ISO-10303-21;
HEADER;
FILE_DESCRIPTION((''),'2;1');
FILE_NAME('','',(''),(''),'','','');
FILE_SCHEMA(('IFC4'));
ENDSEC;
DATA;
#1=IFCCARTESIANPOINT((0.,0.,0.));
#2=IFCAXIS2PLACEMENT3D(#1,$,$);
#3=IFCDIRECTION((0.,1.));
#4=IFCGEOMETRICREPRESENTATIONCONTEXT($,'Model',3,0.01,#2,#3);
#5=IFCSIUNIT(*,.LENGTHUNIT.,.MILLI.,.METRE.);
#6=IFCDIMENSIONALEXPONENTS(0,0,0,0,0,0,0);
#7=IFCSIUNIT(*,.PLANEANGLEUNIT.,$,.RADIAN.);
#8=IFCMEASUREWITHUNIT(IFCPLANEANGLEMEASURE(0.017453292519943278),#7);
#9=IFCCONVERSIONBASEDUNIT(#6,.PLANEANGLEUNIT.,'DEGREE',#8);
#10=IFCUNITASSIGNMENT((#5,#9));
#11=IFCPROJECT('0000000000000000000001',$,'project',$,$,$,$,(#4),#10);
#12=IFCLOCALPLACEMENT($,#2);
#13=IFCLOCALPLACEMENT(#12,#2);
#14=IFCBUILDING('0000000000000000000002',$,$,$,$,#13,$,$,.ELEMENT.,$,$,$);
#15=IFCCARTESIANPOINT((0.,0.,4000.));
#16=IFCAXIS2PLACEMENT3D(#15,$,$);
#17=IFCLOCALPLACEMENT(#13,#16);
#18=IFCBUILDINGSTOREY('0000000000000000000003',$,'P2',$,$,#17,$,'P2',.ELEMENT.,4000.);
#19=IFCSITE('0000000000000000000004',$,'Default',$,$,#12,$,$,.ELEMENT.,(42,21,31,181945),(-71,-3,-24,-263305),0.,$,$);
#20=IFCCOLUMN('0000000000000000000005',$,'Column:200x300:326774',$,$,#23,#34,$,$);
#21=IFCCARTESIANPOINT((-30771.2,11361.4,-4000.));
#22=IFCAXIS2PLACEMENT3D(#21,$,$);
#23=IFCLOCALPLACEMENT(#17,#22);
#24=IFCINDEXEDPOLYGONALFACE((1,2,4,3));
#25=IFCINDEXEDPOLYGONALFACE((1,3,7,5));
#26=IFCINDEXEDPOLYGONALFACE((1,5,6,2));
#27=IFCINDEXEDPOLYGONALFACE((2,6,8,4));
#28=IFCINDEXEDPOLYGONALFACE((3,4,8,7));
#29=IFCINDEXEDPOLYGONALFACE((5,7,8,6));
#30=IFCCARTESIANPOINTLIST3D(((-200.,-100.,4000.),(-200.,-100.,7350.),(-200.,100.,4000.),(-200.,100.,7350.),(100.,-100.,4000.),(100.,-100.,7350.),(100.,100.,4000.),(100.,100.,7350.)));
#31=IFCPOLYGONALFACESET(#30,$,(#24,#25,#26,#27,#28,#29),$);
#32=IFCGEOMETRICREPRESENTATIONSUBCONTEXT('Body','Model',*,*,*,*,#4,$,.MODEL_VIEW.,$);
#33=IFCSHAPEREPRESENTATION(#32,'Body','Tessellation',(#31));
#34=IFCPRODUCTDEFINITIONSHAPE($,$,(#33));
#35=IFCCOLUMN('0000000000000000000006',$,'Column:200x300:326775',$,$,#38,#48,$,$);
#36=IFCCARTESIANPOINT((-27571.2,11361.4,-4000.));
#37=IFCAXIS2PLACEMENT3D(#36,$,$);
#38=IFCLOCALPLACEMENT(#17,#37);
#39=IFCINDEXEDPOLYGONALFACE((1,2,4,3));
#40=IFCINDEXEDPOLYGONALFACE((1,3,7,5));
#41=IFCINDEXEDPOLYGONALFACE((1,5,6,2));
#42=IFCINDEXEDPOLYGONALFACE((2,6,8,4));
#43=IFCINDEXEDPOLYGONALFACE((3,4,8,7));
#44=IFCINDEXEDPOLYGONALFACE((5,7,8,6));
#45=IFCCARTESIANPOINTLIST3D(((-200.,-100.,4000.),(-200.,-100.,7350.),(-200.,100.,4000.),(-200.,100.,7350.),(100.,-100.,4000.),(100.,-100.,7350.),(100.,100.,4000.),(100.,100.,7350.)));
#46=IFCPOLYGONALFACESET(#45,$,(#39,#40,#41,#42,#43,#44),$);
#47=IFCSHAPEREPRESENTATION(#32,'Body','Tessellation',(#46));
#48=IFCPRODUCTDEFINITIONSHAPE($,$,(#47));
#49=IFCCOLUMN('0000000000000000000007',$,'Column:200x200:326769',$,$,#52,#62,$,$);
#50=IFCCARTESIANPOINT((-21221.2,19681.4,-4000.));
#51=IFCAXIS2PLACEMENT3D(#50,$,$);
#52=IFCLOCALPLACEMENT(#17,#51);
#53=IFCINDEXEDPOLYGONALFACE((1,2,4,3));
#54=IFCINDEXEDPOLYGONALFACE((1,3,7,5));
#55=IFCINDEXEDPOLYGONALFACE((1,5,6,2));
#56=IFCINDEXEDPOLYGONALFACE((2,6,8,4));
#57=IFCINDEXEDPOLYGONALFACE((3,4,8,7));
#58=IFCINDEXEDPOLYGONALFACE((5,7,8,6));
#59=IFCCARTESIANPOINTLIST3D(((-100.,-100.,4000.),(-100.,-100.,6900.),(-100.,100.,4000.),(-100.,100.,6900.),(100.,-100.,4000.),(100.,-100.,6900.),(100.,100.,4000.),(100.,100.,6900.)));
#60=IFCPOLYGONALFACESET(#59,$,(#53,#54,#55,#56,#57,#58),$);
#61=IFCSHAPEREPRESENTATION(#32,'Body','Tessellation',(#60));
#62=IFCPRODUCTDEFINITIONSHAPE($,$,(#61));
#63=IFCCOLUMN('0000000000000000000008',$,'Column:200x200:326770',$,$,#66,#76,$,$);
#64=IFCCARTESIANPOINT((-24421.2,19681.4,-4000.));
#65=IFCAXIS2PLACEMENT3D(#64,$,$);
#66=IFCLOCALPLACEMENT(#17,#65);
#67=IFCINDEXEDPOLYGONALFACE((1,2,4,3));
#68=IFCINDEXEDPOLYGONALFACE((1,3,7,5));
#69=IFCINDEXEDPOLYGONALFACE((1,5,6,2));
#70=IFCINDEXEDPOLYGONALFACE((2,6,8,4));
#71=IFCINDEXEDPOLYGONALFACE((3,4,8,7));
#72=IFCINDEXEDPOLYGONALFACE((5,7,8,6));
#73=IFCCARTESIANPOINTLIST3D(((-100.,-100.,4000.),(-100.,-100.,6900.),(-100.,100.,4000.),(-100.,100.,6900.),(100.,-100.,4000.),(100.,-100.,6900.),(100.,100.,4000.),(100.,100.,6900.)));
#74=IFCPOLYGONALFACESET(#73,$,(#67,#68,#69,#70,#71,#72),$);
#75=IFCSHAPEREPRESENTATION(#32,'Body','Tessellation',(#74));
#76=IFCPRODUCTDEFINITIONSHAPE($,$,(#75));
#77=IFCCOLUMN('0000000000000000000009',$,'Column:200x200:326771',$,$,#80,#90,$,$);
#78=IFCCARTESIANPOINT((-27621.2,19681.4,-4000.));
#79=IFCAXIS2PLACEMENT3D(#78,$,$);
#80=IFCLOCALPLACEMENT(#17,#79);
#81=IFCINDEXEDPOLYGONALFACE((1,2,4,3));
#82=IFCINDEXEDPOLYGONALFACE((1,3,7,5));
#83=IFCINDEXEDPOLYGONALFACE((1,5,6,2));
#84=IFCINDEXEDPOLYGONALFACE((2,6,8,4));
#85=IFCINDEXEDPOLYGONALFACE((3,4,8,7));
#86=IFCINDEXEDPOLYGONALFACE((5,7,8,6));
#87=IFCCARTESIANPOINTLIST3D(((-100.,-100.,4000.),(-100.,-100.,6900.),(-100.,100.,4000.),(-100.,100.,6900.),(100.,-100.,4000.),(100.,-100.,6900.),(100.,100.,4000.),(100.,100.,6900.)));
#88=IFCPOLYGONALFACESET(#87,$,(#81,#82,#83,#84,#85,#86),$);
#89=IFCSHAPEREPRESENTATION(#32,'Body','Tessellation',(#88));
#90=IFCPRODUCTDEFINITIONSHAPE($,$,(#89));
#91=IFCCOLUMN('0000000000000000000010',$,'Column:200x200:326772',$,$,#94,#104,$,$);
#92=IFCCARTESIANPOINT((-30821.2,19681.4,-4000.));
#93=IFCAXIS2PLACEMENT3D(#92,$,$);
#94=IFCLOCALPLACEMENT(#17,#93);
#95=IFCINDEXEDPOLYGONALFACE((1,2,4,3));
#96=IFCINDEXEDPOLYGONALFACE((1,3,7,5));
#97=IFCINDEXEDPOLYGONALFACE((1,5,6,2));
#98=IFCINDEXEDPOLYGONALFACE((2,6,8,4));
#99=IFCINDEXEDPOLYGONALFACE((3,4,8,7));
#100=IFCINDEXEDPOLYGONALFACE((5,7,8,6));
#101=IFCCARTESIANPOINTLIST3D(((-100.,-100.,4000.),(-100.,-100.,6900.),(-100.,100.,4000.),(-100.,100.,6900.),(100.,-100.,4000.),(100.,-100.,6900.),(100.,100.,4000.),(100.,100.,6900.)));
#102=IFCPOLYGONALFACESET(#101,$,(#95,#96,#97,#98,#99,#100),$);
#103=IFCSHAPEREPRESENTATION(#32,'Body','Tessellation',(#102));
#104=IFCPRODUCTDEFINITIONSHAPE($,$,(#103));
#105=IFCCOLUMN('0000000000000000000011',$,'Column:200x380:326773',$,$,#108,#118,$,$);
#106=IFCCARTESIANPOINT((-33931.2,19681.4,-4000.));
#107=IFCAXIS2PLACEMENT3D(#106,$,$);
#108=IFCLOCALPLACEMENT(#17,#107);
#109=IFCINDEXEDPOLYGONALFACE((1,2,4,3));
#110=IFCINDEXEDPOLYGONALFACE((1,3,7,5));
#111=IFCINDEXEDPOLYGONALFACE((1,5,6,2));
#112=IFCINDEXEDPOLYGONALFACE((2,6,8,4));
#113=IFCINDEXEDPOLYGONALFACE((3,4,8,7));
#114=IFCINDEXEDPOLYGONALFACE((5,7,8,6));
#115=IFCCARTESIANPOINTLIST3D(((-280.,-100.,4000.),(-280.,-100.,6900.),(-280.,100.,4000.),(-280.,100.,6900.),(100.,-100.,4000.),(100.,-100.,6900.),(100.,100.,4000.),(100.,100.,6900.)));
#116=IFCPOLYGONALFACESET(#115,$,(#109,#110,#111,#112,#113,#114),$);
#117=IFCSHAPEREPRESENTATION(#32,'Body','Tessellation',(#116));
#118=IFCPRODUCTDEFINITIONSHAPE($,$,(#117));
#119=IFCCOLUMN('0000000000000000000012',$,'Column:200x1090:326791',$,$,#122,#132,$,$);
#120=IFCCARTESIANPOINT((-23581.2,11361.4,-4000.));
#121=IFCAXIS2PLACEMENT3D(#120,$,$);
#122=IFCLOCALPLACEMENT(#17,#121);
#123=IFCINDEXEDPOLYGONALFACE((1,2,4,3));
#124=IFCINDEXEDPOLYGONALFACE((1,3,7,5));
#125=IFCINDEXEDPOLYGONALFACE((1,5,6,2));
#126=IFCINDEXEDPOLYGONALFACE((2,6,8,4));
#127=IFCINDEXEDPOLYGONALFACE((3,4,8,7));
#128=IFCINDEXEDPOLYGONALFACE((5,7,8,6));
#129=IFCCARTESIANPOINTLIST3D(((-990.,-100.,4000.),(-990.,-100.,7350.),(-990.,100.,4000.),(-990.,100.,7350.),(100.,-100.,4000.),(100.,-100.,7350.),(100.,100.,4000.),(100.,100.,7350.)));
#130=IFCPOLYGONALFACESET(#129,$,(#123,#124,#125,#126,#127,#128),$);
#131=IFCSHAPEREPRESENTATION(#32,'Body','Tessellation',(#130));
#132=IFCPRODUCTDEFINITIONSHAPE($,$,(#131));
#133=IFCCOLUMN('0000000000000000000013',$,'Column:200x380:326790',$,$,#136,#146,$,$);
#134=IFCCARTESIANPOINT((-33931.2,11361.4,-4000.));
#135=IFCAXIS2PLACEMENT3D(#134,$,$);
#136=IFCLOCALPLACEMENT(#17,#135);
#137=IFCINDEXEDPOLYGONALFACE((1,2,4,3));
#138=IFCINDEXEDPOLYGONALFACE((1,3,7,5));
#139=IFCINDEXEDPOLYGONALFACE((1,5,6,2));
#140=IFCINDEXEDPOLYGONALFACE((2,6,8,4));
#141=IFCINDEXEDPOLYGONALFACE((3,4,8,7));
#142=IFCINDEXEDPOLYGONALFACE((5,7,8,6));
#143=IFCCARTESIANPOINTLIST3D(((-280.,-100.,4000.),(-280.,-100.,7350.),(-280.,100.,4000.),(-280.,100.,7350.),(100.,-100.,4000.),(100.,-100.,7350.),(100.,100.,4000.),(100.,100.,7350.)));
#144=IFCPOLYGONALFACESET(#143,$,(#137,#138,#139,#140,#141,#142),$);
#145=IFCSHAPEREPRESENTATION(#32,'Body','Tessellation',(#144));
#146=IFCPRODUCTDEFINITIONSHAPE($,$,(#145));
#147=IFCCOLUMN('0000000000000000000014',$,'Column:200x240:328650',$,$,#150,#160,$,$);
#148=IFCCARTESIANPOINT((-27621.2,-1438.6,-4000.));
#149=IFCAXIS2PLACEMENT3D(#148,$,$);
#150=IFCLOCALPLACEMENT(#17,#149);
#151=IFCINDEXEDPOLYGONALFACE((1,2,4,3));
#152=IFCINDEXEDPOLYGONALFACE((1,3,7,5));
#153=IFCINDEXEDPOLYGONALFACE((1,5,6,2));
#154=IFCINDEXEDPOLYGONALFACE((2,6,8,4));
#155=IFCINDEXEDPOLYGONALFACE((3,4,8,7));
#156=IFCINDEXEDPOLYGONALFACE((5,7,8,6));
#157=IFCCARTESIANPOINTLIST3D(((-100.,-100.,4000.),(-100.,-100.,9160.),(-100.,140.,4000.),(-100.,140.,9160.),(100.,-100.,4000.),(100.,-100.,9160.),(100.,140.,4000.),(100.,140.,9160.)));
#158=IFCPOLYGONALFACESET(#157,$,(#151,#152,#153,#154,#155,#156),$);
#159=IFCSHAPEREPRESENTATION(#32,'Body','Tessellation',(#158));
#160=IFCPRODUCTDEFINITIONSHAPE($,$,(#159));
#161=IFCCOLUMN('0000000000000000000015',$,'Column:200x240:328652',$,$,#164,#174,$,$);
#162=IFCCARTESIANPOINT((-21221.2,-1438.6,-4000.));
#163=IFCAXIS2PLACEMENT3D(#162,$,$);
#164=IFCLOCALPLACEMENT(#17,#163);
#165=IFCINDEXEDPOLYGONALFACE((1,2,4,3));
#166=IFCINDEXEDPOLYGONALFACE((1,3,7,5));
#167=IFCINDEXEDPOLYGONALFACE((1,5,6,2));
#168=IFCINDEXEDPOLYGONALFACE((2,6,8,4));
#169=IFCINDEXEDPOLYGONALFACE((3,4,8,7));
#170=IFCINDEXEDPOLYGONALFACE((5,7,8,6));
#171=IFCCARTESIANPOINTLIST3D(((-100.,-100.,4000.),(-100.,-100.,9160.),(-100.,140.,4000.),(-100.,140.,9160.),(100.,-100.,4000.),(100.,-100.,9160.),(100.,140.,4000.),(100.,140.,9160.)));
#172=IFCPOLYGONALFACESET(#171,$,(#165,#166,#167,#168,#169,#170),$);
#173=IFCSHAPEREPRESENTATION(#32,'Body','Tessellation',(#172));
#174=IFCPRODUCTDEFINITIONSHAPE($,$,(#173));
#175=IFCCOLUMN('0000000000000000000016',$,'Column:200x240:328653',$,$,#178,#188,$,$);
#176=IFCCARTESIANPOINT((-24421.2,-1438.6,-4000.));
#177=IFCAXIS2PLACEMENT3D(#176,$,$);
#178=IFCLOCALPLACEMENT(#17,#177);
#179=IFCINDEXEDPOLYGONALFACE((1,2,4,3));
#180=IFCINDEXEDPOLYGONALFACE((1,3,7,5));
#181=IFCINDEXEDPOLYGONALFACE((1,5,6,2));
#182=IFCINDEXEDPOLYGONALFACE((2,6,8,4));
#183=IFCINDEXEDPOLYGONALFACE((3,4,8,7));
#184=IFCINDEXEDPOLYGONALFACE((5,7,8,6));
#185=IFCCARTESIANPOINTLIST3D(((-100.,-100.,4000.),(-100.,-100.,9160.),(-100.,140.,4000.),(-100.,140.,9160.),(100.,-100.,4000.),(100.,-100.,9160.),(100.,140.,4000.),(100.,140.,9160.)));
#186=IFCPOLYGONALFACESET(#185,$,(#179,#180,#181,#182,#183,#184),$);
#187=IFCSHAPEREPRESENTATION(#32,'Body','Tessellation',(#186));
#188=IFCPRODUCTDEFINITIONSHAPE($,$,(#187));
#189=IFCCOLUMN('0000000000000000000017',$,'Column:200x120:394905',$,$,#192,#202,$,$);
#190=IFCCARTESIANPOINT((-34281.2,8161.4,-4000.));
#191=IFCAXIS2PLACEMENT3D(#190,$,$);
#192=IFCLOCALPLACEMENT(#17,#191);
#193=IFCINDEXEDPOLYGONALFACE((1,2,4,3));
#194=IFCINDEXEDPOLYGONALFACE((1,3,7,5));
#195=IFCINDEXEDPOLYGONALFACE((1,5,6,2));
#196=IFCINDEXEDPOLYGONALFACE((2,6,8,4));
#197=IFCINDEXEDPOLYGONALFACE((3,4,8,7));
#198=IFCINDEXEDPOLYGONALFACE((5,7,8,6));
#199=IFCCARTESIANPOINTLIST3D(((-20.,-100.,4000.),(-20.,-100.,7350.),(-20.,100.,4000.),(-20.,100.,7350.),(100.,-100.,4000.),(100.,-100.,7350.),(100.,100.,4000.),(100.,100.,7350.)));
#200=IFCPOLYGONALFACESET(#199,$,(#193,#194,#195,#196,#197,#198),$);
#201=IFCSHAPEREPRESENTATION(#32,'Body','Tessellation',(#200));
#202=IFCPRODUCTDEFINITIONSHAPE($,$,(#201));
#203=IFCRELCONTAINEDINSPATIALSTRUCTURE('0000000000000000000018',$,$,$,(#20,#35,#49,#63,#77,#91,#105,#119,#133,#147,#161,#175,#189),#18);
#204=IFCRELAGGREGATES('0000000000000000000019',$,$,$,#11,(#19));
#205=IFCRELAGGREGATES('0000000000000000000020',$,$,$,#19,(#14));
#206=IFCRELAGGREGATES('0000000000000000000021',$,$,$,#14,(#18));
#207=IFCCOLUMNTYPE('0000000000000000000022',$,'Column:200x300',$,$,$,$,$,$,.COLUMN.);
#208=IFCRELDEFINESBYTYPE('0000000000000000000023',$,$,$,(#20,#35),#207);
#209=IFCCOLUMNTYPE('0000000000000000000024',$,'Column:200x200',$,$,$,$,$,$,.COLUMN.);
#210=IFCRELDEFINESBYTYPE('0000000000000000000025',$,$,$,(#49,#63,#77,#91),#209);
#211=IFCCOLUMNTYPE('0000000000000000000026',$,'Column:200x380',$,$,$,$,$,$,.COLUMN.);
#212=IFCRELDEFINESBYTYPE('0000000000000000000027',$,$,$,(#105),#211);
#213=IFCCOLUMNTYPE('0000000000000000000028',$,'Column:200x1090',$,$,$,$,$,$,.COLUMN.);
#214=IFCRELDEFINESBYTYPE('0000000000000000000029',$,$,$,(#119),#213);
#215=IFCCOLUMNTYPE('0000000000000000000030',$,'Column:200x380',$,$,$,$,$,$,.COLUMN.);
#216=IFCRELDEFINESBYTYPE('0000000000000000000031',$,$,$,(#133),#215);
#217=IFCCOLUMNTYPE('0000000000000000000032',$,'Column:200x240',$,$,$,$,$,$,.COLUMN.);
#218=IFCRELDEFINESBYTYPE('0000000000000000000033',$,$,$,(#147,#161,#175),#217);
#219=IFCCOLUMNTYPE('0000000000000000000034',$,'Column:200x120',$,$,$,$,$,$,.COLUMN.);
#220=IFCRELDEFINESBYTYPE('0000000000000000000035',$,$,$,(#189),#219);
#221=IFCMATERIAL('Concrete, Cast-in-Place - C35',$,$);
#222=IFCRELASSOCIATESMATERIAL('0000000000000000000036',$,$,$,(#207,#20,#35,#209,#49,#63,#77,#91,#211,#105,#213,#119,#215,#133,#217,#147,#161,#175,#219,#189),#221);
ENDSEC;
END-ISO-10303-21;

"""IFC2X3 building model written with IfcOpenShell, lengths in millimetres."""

from ifc_helpers import new_model, entity, si_unit, converted_unit, direction, frame, frame_2d, origin, origin_2d_with_axis, place, context, subcontext, project, spatial, rectangle, extrude, source, transform, mapped, material, type_object, type_shapes, element, save


model = new_model("IFC2X3")

# Units and contexts
model_context = context("Model", 3, precision=0.01, world=origin(), true_north=direction((0.0, 1.0)))
body_context = subcontext(model_context, "Body", "Model", "MODEL_VIEW")
ifc_project = project(units=[si_unit("LENGTHUNIT", "METRE", prefix="MILLI"), converted_unit("PLANEANGLEUNIT", "DEGREE", entity("IfcPlaneAngleMeasure", 0.017453292519943278), si_unit("PLANEANGLEUNIT", "RADIAN"), dimensions=[0, 0, 0, 0, 0, 0, 0])], contexts=[model_context])

# Site, building, storey
site_placement = place(None, origin())
site = spatial("IfcSite", under=ifc_project, at=site_placement, Name="Default", CompositionType="ELEMENT", RefLatitude=(42, 21, 31, 181945), RefLongitude=(-71, -3, -24, -263305), RefElevation=0.0)
building_placement = place(site_placement, origin())
building = spatial("IfcBuilding", under=site, at=building_placement, CompositionType="ELEMENT")
storey_placement = place(building_placement, frame((0.0, 0.0, 4000.0)))
storey = spatial("IfcBuildingStorey", under=building, at=storey_placement, Name="P2", LongName="P2", CompositionType="ELEMENT", Elevation=4000.0)

# Columns
ifc_material = material(Name="Concrete, Cast-in-Place - C35")
column_type_1 = type_object("IfcColumnType", Name="Column:200x300", PredefinedType="COLUMN", material=ifc_material)
shared_shape_1 = source(origin(), body_context, "Body", "SweptSolid", [
    extrude(rectangle(XDim=300.0, YDim=200.0, at=origin_2d_with_axis()), frame((-50.0, 0.0, 4000.0), z_axis=(0.0, 0.0, 1.0), x_axis=(-1.0, 0.0, 0.0)), (0.0, 0.0, 1.0), 3350.0),
])
type_shapes(column_type_1, [shared_shape_1])
for number, where, name in (
    (1, (-30771.2, 11361.4, -4000.0), "Column:200x300:326774"),
    (2, (-27571.2, 11361.4, -4000.0), "Column:200x300:326775"),
):
    element("IfcColumn", number, at=place(storey_placement, frame(where)), inside=storey, type_object=column_type_1, material=ifc_material, Name=name, context=body_context, shape_type="MappedRepresentation", body=[
        mapped(shared_shape_1, transform((0.0, 0.0, 0.0), scale=1.0)),
    ])
column_type_2 = type_object("IfcColumnType", Name="Column:200x200", PredefinedType="COLUMN", material=ifc_material)
shared_shape_2 = source(origin(), body_context, "Body", "SweptSolid", [
    extrude(rectangle(XDim=200.0, YDim=200.0, at=frame_2d((0.0, 0.0), x_axis=(1.0, 0.0))), frame((0.0, 0.0, 4000.0), z_axis=(0.0, 0.0, 1.0), x_axis=(-1.0, 0.0, 0.0)), (0.0, 0.0, 1.0), 2900.0),
])
type_shapes(column_type_2, [shared_shape_2])
for number, where, name in (
    (3, (-21221.2, 19681.4, -4000.0), "Column:200x200:326769"),
    (4, (-24421.2, 19681.4, -4000.0), "Column:200x200:326770"),
    (5, (-27621.2, 19681.4, -4000.0), "Column:200x200:326771"),
    (6, (-30821.2, 19681.4, -4000.0), "Column:200x200:326772"),
):
    element("IfcColumn", number, at=place(storey_placement, frame(where)), inside=storey, type_object=column_type_2, material=ifc_material, Name=name, context=body_context, shape_type="MappedRepresentation", body=[
        mapped(shared_shape_2, transform((0.0, 0.0, 0.0), scale=1.0)),
    ])
column_type_3 = type_object("IfcColumnType", Name="Column:200x380", PredefinedType="COLUMN", material=ifc_material)
shared_shape_3 = source(origin(), body_context, "Body", "SweptSolid", [
    extrude(rectangle(XDim=380.0, YDim=200.0, at=origin_2d_with_axis()), frame((-90.0, 0.0, 4000.0), z_axis=(0.0, 0.0, 1.0), x_axis=(-1.0, 0.0, 0.0)), (0.0, 0.0, 1.0), 2900.0),
])
type_shapes(column_type_3, [shared_shape_3])
column_1_placement = place(storey_placement, frame((-33931.2, 19681.4, -4000.0)))
element("IfcColumn", 7, at=column_1_placement, inside=storey, type_object=column_type_3, material=ifc_material, Name="Column:200x380:326773", context=body_context, shape_type="MappedRepresentation", body=[
    mapped(shared_shape_3, transform((0.0, 0.0, 0.0), scale=1.0)),
])
column_type_4 = type_object("IfcColumnType", Name="Column:200x1090", PredefinedType="COLUMN", material=ifc_material)
shared_shape_4 = source(origin(), body_context, "Body", "SweptSolid", [
    extrude(rectangle(XDim=1090.0, YDim=200.0, at=origin_2d_with_axis()), frame((-445.0, 0.0, 4000.0), z_axis=(0.0, 0.0, 1.0), x_axis=(-1.0, 0.0, 0.0)), (0.0, 0.0, 1.0), 3350.0),
])
type_shapes(column_type_4, [shared_shape_4])
column_2_placement = place(storey_placement, frame((-23581.2, 11361.4, -4000.0)))
element("IfcColumn", 8, at=column_2_placement, inside=storey, type_object=column_type_4, material=ifc_material, Name="Column:200x1090:326791", context=body_context, shape_type="MappedRepresentation", body=[
    mapped(shared_shape_4, transform((0.0, 0.0, 0.0), scale=1.0)),
])
column_type_5 = type_object("IfcColumnType", Name="Column:200x380", PredefinedType="COLUMN", material=ifc_material)
shared_shape_5 = source(origin(), body_context, "Body", "SweptSolid", [
    extrude(rectangle(XDim=380.0, YDim=200.0, at=origin_2d_with_axis()), frame((-90.0, 0.0, 4000.0), z_axis=(0.0, 0.0, 1.0), x_axis=(-1.0, 0.0, 0.0)), (0.0, 0.0, 1.0), 3350.0),
])
type_shapes(column_type_5, [shared_shape_5])
column_3_placement = place(storey_placement, frame((-33931.2, 11361.4, -4000.0)))
element("IfcColumn", 9, at=column_3_placement, inside=storey, type_object=column_type_5, material=ifc_material, Name="Column:200x380:326790", context=body_context, shape_type="MappedRepresentation", body=[
    mapped(shared_shape_5, transform((0.0, 0.0, 0.0), scale=1.0)),
])
column_type_6 = type_object("IfcColumnType", Name="Column:200x240", PredefinedType="COLUMN", material=ifc_material)
shared_shape_6 = source(origin(), body_context, "Body", "SweptSolid", [
    extrude(rectangle(XDim=200.0, YDim=240.0, at=origin_2d_with_axis()), frame((0.0, 20.0, 4000.0), z_axis=(0.0, 0.0, 1.0), x_axis=(-1.0, 0.0, 0.0)), (0.0, 0.0, 1.0), 5160.0),
])
type_shapes(column_type_6, [shared_shape_6])
for number, where, name in (
    (10, (-27621.2, -1438.6, -4000.0), "Column:200x240:328650"),
    (11, (-21221.2, -1438.6, -4000.0), "Column:200x240:328652"),
    (12, (-24421.2, -1438.6, -4000.0), "Column:200x240:328653"),
):
    element("IfcColumn", number, at=place(storey_placement, frame(where)), inside=storey, type_object=column_type_6, material=ifc_material, Name=name, context=body_context, shape_type="MappedRepresentation", body=[
        mapped(shared_shape_6, transform((0.0, 0.0, 0.0), scale=1.0)),
    ])
column_type_7 = type_object("IfcColumnType", Name="Column:200x120", PredefinedType="COLUMN", material=ifc_material)
shared_shape_7 = source(origin(), body_context, "Body", "SweptSolid", [
    extrude(rectangle(XDim=120.0, YDim=200.0, at=origin_2d_with_axis()), frame((40.0, 0.0, 4000.0), z_axis=(0.0, 0.0, 1.0), x_axis=(-1.0, 0.0, 0.0)), (0.0, 0.0, 1.0), 3350.0),
])
type_shapes(column_type_7, [shared_shape_7])
for number, where, name in (
    (13, (-34281.2, 8161.4, -4000.0), "Column:200x120:394905"),
):
    element("IfcColumn", number, at=place(storey_placement, frame(where)), inside=storey, type_object=column_type_7, material=ifc_material, Name=name, context=body_context, shape_type="MappedRepresentation", body=[
        mapped(shared_shape_7, transform((0.0, 0.0, 0.0), scale=1.0)),
    ])

save(model, "model.ifc")
